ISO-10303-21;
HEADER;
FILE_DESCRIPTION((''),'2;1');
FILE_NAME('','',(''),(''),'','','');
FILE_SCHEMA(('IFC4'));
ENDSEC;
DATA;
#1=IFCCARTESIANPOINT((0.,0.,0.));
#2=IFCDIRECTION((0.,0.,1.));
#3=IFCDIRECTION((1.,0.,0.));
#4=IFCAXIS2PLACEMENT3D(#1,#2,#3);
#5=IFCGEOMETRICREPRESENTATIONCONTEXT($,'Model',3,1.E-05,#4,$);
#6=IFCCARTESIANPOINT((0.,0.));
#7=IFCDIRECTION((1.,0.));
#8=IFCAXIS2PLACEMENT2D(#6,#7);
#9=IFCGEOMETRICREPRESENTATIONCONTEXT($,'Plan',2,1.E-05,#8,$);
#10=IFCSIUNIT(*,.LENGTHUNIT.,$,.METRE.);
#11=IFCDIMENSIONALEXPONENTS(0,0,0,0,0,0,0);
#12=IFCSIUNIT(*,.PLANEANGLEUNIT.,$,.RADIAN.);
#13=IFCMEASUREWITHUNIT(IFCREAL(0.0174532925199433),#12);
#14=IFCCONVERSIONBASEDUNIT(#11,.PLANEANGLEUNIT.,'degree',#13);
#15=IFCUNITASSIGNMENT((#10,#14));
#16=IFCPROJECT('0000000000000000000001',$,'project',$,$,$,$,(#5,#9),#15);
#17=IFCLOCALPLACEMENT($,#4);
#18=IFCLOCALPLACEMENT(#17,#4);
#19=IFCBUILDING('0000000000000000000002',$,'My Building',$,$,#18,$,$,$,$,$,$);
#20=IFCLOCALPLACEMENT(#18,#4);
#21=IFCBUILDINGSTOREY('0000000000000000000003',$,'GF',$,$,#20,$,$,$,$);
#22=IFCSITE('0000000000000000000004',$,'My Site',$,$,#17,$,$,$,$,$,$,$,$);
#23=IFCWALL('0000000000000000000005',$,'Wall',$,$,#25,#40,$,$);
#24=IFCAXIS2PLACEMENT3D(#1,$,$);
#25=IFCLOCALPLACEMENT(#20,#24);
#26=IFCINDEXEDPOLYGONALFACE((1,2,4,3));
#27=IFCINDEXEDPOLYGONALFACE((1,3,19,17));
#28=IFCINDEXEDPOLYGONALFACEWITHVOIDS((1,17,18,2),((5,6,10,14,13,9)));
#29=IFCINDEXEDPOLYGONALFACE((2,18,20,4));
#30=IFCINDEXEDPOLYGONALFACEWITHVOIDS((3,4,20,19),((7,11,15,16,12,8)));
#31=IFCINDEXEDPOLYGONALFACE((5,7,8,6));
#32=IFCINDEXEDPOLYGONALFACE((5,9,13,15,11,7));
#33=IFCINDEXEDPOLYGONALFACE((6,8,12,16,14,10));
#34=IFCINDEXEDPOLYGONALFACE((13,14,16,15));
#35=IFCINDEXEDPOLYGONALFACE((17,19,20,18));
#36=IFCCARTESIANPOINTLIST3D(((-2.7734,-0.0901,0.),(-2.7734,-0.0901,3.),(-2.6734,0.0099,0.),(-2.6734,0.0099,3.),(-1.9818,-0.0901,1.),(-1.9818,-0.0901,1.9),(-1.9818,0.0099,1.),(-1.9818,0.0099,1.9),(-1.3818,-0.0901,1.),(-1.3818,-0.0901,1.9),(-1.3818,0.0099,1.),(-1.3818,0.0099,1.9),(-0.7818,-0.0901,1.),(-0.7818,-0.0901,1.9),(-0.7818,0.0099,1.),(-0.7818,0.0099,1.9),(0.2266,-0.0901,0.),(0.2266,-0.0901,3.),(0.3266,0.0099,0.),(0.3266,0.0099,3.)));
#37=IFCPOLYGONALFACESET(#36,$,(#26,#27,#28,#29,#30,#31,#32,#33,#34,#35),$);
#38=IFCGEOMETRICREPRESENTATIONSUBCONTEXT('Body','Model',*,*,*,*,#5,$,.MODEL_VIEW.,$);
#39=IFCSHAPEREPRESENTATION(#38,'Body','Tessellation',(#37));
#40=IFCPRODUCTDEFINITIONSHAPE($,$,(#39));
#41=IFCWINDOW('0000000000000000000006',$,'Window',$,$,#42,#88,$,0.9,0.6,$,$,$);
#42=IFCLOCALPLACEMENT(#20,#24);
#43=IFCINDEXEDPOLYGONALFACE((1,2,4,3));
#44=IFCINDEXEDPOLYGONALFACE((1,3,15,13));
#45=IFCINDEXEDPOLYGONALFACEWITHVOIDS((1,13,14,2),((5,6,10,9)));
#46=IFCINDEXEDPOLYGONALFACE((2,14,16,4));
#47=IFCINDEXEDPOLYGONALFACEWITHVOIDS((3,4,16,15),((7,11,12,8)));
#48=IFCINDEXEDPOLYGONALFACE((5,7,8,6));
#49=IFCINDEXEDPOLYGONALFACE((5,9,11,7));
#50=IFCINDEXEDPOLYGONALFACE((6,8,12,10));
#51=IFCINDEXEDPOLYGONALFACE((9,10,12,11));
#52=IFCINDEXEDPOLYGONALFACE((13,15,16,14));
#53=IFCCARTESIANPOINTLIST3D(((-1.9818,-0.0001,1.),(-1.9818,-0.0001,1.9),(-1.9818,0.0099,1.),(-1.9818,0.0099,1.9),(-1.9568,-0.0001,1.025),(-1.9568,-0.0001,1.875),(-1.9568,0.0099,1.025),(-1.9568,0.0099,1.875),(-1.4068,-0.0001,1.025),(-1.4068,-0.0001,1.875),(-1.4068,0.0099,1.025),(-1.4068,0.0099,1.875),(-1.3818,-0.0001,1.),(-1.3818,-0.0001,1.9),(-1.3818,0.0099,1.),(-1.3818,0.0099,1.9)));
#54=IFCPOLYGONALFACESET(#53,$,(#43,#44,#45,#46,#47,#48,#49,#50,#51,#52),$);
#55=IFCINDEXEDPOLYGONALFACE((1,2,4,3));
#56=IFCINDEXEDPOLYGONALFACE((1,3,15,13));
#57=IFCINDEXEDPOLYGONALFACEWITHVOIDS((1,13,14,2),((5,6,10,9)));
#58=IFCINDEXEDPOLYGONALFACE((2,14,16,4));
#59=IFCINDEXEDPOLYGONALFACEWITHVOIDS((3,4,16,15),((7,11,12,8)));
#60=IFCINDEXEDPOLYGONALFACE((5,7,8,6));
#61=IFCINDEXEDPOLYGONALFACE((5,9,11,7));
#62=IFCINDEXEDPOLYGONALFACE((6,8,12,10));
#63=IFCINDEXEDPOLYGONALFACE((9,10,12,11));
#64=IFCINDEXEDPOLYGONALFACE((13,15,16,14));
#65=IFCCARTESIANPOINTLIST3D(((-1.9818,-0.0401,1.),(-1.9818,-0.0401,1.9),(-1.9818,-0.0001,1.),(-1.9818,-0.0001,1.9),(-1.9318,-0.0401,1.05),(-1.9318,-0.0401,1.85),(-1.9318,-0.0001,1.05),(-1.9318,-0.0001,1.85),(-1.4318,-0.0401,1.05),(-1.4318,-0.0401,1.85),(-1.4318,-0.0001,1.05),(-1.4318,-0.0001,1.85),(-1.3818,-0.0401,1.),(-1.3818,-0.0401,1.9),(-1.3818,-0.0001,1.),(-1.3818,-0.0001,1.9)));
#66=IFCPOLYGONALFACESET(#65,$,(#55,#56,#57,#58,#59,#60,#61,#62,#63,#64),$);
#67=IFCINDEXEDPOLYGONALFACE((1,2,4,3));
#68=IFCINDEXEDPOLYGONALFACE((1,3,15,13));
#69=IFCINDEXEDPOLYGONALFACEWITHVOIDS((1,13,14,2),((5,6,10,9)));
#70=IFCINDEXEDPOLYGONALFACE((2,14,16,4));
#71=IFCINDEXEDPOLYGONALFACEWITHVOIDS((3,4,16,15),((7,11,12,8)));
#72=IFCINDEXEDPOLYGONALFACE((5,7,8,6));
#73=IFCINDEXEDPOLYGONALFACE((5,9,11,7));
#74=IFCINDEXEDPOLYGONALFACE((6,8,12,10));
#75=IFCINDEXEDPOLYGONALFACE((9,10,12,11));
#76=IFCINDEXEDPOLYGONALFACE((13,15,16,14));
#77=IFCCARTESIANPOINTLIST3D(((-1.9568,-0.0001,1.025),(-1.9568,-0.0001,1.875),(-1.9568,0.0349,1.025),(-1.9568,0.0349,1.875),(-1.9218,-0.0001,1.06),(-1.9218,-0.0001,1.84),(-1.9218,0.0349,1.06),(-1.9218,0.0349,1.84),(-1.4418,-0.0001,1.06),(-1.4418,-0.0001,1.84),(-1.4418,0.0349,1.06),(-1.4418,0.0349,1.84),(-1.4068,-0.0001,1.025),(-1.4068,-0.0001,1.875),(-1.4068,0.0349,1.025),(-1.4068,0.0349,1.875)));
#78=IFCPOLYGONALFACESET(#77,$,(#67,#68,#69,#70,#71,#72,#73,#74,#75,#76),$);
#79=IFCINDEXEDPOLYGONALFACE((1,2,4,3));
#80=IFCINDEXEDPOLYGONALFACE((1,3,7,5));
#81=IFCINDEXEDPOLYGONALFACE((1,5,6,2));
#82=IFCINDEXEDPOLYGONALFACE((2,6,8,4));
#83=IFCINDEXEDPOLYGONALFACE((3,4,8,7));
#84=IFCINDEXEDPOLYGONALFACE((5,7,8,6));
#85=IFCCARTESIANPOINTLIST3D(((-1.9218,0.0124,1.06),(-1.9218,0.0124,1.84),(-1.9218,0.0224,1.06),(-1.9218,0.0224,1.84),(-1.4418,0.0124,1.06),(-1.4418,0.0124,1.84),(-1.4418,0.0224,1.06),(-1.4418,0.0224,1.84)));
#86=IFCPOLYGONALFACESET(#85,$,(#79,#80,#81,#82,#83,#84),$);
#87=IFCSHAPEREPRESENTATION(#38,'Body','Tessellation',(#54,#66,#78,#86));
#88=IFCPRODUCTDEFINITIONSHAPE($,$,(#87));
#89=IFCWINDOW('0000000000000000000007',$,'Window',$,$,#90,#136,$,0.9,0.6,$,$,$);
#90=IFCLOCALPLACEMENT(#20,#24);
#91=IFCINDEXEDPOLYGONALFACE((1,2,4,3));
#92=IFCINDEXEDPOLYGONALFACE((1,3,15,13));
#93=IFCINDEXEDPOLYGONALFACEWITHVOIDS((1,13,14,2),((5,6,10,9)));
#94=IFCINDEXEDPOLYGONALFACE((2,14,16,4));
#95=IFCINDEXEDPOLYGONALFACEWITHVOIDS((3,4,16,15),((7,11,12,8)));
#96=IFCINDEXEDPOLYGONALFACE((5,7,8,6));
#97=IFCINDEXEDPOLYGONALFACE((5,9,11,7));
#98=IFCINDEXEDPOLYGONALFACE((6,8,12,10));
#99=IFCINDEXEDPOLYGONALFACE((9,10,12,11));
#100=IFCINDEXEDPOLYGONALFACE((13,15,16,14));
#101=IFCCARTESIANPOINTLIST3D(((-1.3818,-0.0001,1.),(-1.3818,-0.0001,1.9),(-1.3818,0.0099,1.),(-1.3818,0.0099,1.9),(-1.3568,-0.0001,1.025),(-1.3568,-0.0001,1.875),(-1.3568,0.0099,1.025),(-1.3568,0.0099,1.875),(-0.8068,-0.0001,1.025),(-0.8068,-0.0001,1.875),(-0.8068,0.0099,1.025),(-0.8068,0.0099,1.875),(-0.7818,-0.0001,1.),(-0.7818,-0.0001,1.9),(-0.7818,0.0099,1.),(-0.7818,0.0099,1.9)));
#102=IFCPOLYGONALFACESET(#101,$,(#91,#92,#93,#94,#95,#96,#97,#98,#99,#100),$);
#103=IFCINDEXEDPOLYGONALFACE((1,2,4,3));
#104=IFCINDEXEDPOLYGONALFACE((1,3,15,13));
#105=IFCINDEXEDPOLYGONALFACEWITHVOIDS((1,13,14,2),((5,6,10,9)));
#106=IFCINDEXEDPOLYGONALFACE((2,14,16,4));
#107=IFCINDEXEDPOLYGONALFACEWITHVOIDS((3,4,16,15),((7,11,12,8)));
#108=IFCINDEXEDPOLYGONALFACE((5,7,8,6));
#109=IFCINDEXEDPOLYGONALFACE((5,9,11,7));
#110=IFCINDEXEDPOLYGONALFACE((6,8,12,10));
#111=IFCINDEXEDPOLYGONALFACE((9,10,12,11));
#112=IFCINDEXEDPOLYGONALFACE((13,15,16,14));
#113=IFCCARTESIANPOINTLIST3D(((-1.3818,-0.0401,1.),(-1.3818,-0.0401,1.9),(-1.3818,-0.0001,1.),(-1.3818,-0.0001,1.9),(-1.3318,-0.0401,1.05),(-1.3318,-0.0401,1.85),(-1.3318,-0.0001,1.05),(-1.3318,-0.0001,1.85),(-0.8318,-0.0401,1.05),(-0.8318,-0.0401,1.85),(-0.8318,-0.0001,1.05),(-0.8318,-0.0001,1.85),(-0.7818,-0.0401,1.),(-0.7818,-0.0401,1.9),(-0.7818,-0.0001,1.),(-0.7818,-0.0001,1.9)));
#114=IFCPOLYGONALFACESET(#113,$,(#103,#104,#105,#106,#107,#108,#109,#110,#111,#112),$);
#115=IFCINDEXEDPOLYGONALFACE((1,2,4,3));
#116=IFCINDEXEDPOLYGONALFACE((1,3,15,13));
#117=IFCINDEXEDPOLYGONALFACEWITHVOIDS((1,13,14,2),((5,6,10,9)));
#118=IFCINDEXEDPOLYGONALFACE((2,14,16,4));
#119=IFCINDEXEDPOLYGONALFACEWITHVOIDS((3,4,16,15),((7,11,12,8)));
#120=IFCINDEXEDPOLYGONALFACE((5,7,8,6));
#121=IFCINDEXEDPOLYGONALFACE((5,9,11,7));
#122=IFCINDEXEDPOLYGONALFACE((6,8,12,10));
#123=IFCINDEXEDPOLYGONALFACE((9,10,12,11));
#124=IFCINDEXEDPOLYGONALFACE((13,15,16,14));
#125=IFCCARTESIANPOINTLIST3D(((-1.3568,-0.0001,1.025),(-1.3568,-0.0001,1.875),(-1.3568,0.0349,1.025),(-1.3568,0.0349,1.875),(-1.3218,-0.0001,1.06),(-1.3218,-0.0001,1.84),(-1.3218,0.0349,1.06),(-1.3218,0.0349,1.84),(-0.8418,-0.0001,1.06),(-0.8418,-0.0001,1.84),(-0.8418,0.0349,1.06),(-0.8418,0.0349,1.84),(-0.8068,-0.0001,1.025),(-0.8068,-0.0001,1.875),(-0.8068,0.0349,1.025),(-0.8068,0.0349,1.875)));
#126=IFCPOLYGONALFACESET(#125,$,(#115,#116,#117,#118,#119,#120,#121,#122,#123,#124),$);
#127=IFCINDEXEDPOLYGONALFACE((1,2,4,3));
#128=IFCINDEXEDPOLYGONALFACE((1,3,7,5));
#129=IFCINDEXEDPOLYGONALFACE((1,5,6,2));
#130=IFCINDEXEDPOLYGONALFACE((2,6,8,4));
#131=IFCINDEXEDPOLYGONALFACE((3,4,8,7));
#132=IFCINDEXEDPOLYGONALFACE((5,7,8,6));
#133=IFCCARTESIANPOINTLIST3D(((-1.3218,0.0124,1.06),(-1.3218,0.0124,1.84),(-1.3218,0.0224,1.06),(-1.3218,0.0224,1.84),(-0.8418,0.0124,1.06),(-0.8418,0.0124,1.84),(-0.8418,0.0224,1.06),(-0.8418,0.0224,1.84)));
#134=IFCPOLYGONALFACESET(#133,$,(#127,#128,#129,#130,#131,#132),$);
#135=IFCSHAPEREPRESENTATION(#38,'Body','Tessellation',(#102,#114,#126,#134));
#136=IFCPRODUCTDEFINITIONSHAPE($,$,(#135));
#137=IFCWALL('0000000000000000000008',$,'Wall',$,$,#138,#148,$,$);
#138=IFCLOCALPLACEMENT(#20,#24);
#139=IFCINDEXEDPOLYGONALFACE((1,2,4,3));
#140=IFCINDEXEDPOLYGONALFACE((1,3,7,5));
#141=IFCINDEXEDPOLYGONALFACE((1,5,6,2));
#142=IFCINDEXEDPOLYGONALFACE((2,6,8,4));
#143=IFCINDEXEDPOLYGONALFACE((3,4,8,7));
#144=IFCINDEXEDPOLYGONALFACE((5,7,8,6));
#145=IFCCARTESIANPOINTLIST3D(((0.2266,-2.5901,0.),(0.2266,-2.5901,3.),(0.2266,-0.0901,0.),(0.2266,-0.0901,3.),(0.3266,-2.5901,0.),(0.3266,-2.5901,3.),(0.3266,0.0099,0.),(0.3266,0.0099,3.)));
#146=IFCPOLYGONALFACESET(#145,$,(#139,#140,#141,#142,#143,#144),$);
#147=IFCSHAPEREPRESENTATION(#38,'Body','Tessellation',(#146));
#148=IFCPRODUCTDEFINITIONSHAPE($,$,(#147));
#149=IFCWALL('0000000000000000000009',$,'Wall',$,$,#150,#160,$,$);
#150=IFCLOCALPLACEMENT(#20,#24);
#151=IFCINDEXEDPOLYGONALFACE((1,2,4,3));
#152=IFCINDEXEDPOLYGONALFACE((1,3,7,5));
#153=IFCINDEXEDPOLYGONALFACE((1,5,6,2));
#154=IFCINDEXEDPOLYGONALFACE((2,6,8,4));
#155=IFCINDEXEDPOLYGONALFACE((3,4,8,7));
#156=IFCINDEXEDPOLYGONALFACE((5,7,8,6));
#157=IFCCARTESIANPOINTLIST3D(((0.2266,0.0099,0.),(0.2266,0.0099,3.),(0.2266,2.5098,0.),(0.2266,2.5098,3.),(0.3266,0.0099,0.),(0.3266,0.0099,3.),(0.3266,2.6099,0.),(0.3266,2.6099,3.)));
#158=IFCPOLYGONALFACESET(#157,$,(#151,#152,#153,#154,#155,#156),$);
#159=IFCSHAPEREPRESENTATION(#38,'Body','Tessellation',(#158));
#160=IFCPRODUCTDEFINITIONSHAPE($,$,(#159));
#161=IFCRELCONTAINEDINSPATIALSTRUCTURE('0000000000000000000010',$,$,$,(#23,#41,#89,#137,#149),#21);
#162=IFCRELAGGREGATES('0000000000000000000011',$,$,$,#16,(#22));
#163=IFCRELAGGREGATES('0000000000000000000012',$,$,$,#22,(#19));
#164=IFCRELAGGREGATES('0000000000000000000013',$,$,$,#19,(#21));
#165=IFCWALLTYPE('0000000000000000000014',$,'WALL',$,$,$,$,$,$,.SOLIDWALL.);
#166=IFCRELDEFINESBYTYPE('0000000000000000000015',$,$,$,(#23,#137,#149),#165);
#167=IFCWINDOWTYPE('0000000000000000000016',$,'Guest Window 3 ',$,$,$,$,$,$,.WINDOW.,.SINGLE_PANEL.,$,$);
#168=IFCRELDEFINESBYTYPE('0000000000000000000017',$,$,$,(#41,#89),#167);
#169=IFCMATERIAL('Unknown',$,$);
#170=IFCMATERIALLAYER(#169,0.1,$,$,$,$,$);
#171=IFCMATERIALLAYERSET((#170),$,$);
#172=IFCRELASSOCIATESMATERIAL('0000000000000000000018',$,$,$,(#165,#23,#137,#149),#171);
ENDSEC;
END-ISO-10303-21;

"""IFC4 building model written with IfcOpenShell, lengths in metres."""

from ifc_helpers import new_model, entity, si_unit, converted_unit, frame, origin_with_axes, origin_2d_with_axis, place, context, subcontext, project, spatial, line, indexed_curve, outline, extrude, shape, source, transform, mapped, material, layer, layer_set, layer_usage, type_object, type_shapes, element, fill, save


model = new_model("IFC4")

# Units and contexts
model_context = context("Model", 3, precision=1e-05, world=origin_with_axes())
plan_context = context("Plan", 2, precision=1e-05, world=origin_2d_with_axis())
body_context_1 = subcontext(model_context, "Body", "Model", "MODEL_VIEW")
body_context_2 = subcontext(plan_context, "Body", "Plan", "PLAN_VIEW")
ifc_project = project(units=[si_unit("LENGTHUNIT", "METRE"), converted_unit("PLANEANGLEUNIT", "degree", entity("IfcReal", 0.0174532925199433), si_unit("PLANEANGLEUNIT", "RADIAN"), dimensions=[0, 0, 0, 0, 0, 0, 0])], contexts=[model_context, plan_context])

# Site, building, storey
site_placement = place(None, origin_with_axes())
site = spatial("IfcSite", under=ifc_project, at=site_placement, Name="My Site")
building_placement = place(site_placement, origin_with_axes())
building = spatial("IfcBuilding", under=site, at=building_placement, Name="My Building")
storey_placement = place(building_placement, origin_with_axes())
storey = spatial("IfcBuildingStorey", under=building, at=storey_placement, Name="GF")

# Shared definitions
ifc_material_1 = material(Name="Unknown")

# Shared definitions
ifc_layer_1 = layer(ifc_material_1, 0.1)
ifc_layer_set_1 = layer_set([ifc_layer_1])
wall_type = type_object("IfcWallType", Name="WALL", PredefinedType="SOLIDWALL", material=ifc_layer_set_1)

# Wall, openings, windows
ifc_layer_usage_1 = layer_usage(ifc_layer_set_1, "AXIS2", "POSITIVE", 0.0)
wall_1_placement = place(storey_placement, frame((-2.7734, -0.0901, 0.0), z_axis=(0.0, 0.0, 1.0), x_axis=(1.0, 0.0, 0.0)))
wall_1 = element("IfcWall", 1, at=wall_1_placement, inside=storey, type_object=wall_type, material=ifc_layer_usage_1, Name="Wall", context=body_context_1, shape_type="SweptSolid", body=[
    extrude(outline(indexed_curve([(0.0, 0.0), (0.1, 0.1), (3.1, 0.1), (3.0, 0.0)], segments=[line(1, 2, 3, 4, 1)])), origin_with_axes(), (0.0, 0.0, 1.0), 3.0),
])
shared_shape_1 = source(origin_with_axes(), body_context_1, "Body", "SweptSolid", [
    extrude(outline(indexed_curve([(0.0, 0.0), (0.6, 0.0), (0.6, 0.9), (0.0, 0.9)], segments=[line(1, 2, 3, 4, 1)])), frame((0.0, -0.6, 0.0), z_axis=(0.0, -1.0, 0.0), x_axis=(1.0, 0.0, 0.0)), (0.0, 0.0, -1.0), 1.2),
])
opening_1_placement = place(wall_1_placement, frame((0.7916, 0.0, 1.0), z_axis=(0.0, 0.0, 1.0), x_axis=(1.0, 0.0, 0.0)))
opening_1 = element("IfcOpeningElement", 2, at=opening_1_placement, cuts=wall_1, PredefinedType="OPENING", context=body_context_1, shape_type="MappedRepresentation", body=[
    mapped(shared_shape_1, transform((0.0, 0.0, 0.0), x_axis=(1.0, 0.0, 0.0), y_axis=(0.0, 1.0, 0.0), z_axis=(0.0, 0.0, 1.0), scale=1.0)),
])
opening_2_placement = place(wall_1_placement, frame((1.3916, 0.0, 1.0), z_axis=(0.0, 0.0, 1.0), x_axis=(1.0, 0.0, 0.0)))
opening_2 = element("IfcOpeningElement", 3, at=opening_2_placement, cuts=wall_1, PredefinedType="OPENING", context=body_context_1, shape_type="MappedRepresentation", body=[
    mapped(shared_shape_1, transform((0.0, 0.0, 0.0), x_axis=(1.0, 0.0, 0.0), y_axis=(0.0, 1.0, 0.0), z_axis=(0.0, 0.0, 1.0), scale=1.0)),
])
window_type_1 = type_object("IfcWindowType", Name="Guest Window 3 ", PartitioningType="SINGLE_PANEL", PredefinedType="WINDOW")
shared_shape_2 = source(origin_with_axes(), body_context_1, "Body", "SweptSolid", [
    extrude(outline(indexed_curve([(0.0, 0.0), (0.6, 0.0), (0.6, 0.9), (0.0, 0.9)], segments=[line(1, 2, 3, 4, 1)]), holes=[indexed_curve([(0.025, 0.025), (0.575, 0.025), (0.575, 0.875), (0.025, 0.875)], segments=[line(1, 2, 3, 4, 1)])]), frame((0.0, 0.09, 0.0), z_axis=(0.0, -1.0, 0.0), x_axis=(1.0, 0.0, 0.0)), (0.0, 0.0, -1.0), 0.01),
    extrude(outline(indexed_curve([(0.0, 0.0), (0.6, 0.0), (0.6, 0.9), (0.0, 0.9)], segments=[line(1, 2, 3, 4, 1)]), holes=[indexed_curve([(0.05, 0.05), (0.55, 0.05), (0.55, 0.85), (0.05, 0.85)], segments=[line(1, 2, 3, 4, 1)])]), frame((0.0, 0.05, 0.0), z_axis=(0.0, -1.0, 0.0), x_axis=(1.0, 0.0, 0.0)), (0.0, 0.0, -1.0), 0.04),
    extrude(outline(indexed_curve([(0.0, 0.0), (0.55, 0.0), (0.55, 0.85), (0.0, 0.85)], segments=[line(1, 2, 3, 4, 1)]), holes=[indexed_curve([(0.035, 0.035), (0.515, 0.035), (0.515, 0.815), (0.035, 0.815)], segments=[line(1, 2, 3, 4, 1)])]), frame((0.025, 0.09, 0.025), z_axis=(0.0, -1.0, 0.0), x_axis=(1.0, 0.0, 0.0)), (0.0, 0.0, -1.0), 0.035),
    extrude(outline(indexed_curve([(0.035, 0.035), (0.515, 0.035), (0.515, 0.815), (0.035, 0.815)], segments=[line(1, 2, 3, 4, 1)])), frame((0.025, 0.1025, 0.025), z_axis=(0.0, -1.0, 0.0), x_axis=(1.0, 0.0, 0.0)), (0.0, 0.0, -1.0), 0.01),
])
shared_shape_3 = source(origin_with_axes(), body_context_2, "Body", "Curve2D", [
    entity("IfcIndexedPolyCurve", entity("IfcCartesianPointList2D", [[0.05, 0.05], [0.55, 0.05]])),
    entity("IfcIndexedPolyCurve", entity("IfcCartesianPointList2D", [[0.0, 0.1], [0.025, 0.1], [0.025, 0.09], [0.05, 0.09], [0.05, 0.05], [0.0, 0.05]]), [entity("IfcLineIndex", [1, 2, 3, 4, 5, 6, 1])]),
    entity("IfcIndexedPolyCurve", entity("IfcCartesianPointList2D", [[0.6, 0.1], [0.575, 0.1], [0.575, 0.09], [0.55, 0.09], [0.55, 0.05], [0.6, 0.05]]), [entity("IfcLineIndex", [1, 2, 3, 4, 5, 6, 1])]),
    entity("IfcIndexedPolyCurve", entity("IfcCartesianPointList2D", [[0.025, 0.09], [0.06, 0.09], [0.06, 0.125], [0.025, 0.125]]), [entity("IfcLineIndex", [1, 2, 3, 4, 1])]),
    entity("IfcIndexedPolyCurve", entity("IfcCartesianPointList2D", [[0.575, 0.09], [0.54, 0.09], [0.54, 0.125], [0.575, 0.125]]), [entity("IfcLineIndex", [1, 2, 3, 4, 1])]),
    entity("IfcIndexedPolyCurve", entity("IfcCartesianPointList2D", [[0.06, 0.09], [0.54, 0.09]])),
    entity("IfcIndexedPolyCurve", entity("IfcCartesianPointList2D", [[0.06, 0.125], [0.54, 0.125]])),
    entity("IfcIndexedPolyCurve", entity("IfcCartesianPointList2D", [[0.06, 0.1075], [0.54, 0.1075]])),
])
type_shapes(window_type_1, [shared_shape_2, shared_shape_3])
window_1_placement = place(opening_1_placement, origin_with_axes())
window_1 = element("IfcWindow", 4, at=window_1_placement, inside=storey, type_object=window_type_1, Name="Window", OverallHeight=0.9, OverallWidth=0.6, shapes=[
    shape(body_context_1, "Body", "MappedRepresentation", [mapped(shared_shape_2, transform((0.0, 0.0, 0.0), x_axis=(1.0, 0.0, 0.0), y_axis=(0.0, 1.0, 0.0), z_axis=(0.0, 0.0, 1.0), scale=1.0))]),
    shape(body_context_2, "Body", "MappedRepresentation", [mapped(shared_shape_3, transform((0.0, 0.0, 0.0), x_axis=(1.0, 0.0, 0.0), y_axis=(0.0, 1.0, 0.0), z_axis=(0.0, 0.0, 1.0), scale=1.0))]),
])
fill(opening_1, window_1)
window_2_placement = place(opening_2_placement, origin_with_axes())
window_2 = element("IfcWindow", 5, at=window_2_placement, inside=storey, type_object=window_type_1, Name="Window", OverallHeight=0.9, OverallWidth=0.6, shapes=[
    shape(body_context_1, "Body", "MappedRepresentation", [mapped(shared_shape_2, transform((0.0, 0.0, 0.0), x_axis=(1.0, 0.0, 0.0), y_axis=(0.0, 1.0, 0.0), z_axis=(0.0, 0.0, 1.0), scale=1.0))]),
    shape(body_context_2, "Body", "MappedRepresentation", [mapped(shared_shape_3, transform((0.0, 0.0, 0.0), x_axis=(1.0, 0.0, 0.0), y_axis=(0.0, 1.0, 0.0), z_axis=(0.0, 0.0, 1.0), scale=1.0))]),
])
fill(opening_2, window_2)

# Walls
ifc_layer_usage_2 = layer_usage(ifc_layer_set_1, "AXIS2", "POSITIVE", 0.0)
wall_2_placement = place(storey_placement, frame((0.2266, -0.0901, 0.0), z_axis=(0.0, 0.0, 1.0), x_axis=(0.0, -1.0, 0.0)))
element("IfcWall", 6, at=wall_2_placement, inside=storey, type_object=wall_type, material=ifc_layer_usage_2, Name="Wall", context=body_context_1, shape_type="SweptSolid", body=[
    extrude(outline(indexed_curve([(0.0, 0.0), (-0.1, 0.1), (2.5, 0.1), (2.5, 0.0)], segments=[line(1, 2, 3, 4, 1)])), origin_with_axes(), (0.0, 0.0, 1.0), 3.0),
])
ifc_layer_usage_3 = layer_usage(ifc_layer_set_1, "AXIS2", "POSITIVE", 0.0)
wall_3_placement = place(storey_placement, frame((0.3266, 0.0099, 0.0), z_axis=(0.0, 0.0, 1.0), x_axis=(0.0, 1.0, 0.0)))
element("IfcWall", 7, at=wall_3_placement, inside=storey, type_object=wall_type, material=ifc_layer_usage_3, Name="Wall", context=body_context_1, shape_type="SweptSolid", body=[
    extrude(outline(indexed_curve([(0.0, 0.0), (0.0, 0.1), (2.4999, 0.1), (2.6, 0.0)], segments=[line(1, 2, 3, 4, 1)])), origin_with_axes(), (0.0, 0.0, 1.0), 3.0),
])

save(model, "model.ifc")
